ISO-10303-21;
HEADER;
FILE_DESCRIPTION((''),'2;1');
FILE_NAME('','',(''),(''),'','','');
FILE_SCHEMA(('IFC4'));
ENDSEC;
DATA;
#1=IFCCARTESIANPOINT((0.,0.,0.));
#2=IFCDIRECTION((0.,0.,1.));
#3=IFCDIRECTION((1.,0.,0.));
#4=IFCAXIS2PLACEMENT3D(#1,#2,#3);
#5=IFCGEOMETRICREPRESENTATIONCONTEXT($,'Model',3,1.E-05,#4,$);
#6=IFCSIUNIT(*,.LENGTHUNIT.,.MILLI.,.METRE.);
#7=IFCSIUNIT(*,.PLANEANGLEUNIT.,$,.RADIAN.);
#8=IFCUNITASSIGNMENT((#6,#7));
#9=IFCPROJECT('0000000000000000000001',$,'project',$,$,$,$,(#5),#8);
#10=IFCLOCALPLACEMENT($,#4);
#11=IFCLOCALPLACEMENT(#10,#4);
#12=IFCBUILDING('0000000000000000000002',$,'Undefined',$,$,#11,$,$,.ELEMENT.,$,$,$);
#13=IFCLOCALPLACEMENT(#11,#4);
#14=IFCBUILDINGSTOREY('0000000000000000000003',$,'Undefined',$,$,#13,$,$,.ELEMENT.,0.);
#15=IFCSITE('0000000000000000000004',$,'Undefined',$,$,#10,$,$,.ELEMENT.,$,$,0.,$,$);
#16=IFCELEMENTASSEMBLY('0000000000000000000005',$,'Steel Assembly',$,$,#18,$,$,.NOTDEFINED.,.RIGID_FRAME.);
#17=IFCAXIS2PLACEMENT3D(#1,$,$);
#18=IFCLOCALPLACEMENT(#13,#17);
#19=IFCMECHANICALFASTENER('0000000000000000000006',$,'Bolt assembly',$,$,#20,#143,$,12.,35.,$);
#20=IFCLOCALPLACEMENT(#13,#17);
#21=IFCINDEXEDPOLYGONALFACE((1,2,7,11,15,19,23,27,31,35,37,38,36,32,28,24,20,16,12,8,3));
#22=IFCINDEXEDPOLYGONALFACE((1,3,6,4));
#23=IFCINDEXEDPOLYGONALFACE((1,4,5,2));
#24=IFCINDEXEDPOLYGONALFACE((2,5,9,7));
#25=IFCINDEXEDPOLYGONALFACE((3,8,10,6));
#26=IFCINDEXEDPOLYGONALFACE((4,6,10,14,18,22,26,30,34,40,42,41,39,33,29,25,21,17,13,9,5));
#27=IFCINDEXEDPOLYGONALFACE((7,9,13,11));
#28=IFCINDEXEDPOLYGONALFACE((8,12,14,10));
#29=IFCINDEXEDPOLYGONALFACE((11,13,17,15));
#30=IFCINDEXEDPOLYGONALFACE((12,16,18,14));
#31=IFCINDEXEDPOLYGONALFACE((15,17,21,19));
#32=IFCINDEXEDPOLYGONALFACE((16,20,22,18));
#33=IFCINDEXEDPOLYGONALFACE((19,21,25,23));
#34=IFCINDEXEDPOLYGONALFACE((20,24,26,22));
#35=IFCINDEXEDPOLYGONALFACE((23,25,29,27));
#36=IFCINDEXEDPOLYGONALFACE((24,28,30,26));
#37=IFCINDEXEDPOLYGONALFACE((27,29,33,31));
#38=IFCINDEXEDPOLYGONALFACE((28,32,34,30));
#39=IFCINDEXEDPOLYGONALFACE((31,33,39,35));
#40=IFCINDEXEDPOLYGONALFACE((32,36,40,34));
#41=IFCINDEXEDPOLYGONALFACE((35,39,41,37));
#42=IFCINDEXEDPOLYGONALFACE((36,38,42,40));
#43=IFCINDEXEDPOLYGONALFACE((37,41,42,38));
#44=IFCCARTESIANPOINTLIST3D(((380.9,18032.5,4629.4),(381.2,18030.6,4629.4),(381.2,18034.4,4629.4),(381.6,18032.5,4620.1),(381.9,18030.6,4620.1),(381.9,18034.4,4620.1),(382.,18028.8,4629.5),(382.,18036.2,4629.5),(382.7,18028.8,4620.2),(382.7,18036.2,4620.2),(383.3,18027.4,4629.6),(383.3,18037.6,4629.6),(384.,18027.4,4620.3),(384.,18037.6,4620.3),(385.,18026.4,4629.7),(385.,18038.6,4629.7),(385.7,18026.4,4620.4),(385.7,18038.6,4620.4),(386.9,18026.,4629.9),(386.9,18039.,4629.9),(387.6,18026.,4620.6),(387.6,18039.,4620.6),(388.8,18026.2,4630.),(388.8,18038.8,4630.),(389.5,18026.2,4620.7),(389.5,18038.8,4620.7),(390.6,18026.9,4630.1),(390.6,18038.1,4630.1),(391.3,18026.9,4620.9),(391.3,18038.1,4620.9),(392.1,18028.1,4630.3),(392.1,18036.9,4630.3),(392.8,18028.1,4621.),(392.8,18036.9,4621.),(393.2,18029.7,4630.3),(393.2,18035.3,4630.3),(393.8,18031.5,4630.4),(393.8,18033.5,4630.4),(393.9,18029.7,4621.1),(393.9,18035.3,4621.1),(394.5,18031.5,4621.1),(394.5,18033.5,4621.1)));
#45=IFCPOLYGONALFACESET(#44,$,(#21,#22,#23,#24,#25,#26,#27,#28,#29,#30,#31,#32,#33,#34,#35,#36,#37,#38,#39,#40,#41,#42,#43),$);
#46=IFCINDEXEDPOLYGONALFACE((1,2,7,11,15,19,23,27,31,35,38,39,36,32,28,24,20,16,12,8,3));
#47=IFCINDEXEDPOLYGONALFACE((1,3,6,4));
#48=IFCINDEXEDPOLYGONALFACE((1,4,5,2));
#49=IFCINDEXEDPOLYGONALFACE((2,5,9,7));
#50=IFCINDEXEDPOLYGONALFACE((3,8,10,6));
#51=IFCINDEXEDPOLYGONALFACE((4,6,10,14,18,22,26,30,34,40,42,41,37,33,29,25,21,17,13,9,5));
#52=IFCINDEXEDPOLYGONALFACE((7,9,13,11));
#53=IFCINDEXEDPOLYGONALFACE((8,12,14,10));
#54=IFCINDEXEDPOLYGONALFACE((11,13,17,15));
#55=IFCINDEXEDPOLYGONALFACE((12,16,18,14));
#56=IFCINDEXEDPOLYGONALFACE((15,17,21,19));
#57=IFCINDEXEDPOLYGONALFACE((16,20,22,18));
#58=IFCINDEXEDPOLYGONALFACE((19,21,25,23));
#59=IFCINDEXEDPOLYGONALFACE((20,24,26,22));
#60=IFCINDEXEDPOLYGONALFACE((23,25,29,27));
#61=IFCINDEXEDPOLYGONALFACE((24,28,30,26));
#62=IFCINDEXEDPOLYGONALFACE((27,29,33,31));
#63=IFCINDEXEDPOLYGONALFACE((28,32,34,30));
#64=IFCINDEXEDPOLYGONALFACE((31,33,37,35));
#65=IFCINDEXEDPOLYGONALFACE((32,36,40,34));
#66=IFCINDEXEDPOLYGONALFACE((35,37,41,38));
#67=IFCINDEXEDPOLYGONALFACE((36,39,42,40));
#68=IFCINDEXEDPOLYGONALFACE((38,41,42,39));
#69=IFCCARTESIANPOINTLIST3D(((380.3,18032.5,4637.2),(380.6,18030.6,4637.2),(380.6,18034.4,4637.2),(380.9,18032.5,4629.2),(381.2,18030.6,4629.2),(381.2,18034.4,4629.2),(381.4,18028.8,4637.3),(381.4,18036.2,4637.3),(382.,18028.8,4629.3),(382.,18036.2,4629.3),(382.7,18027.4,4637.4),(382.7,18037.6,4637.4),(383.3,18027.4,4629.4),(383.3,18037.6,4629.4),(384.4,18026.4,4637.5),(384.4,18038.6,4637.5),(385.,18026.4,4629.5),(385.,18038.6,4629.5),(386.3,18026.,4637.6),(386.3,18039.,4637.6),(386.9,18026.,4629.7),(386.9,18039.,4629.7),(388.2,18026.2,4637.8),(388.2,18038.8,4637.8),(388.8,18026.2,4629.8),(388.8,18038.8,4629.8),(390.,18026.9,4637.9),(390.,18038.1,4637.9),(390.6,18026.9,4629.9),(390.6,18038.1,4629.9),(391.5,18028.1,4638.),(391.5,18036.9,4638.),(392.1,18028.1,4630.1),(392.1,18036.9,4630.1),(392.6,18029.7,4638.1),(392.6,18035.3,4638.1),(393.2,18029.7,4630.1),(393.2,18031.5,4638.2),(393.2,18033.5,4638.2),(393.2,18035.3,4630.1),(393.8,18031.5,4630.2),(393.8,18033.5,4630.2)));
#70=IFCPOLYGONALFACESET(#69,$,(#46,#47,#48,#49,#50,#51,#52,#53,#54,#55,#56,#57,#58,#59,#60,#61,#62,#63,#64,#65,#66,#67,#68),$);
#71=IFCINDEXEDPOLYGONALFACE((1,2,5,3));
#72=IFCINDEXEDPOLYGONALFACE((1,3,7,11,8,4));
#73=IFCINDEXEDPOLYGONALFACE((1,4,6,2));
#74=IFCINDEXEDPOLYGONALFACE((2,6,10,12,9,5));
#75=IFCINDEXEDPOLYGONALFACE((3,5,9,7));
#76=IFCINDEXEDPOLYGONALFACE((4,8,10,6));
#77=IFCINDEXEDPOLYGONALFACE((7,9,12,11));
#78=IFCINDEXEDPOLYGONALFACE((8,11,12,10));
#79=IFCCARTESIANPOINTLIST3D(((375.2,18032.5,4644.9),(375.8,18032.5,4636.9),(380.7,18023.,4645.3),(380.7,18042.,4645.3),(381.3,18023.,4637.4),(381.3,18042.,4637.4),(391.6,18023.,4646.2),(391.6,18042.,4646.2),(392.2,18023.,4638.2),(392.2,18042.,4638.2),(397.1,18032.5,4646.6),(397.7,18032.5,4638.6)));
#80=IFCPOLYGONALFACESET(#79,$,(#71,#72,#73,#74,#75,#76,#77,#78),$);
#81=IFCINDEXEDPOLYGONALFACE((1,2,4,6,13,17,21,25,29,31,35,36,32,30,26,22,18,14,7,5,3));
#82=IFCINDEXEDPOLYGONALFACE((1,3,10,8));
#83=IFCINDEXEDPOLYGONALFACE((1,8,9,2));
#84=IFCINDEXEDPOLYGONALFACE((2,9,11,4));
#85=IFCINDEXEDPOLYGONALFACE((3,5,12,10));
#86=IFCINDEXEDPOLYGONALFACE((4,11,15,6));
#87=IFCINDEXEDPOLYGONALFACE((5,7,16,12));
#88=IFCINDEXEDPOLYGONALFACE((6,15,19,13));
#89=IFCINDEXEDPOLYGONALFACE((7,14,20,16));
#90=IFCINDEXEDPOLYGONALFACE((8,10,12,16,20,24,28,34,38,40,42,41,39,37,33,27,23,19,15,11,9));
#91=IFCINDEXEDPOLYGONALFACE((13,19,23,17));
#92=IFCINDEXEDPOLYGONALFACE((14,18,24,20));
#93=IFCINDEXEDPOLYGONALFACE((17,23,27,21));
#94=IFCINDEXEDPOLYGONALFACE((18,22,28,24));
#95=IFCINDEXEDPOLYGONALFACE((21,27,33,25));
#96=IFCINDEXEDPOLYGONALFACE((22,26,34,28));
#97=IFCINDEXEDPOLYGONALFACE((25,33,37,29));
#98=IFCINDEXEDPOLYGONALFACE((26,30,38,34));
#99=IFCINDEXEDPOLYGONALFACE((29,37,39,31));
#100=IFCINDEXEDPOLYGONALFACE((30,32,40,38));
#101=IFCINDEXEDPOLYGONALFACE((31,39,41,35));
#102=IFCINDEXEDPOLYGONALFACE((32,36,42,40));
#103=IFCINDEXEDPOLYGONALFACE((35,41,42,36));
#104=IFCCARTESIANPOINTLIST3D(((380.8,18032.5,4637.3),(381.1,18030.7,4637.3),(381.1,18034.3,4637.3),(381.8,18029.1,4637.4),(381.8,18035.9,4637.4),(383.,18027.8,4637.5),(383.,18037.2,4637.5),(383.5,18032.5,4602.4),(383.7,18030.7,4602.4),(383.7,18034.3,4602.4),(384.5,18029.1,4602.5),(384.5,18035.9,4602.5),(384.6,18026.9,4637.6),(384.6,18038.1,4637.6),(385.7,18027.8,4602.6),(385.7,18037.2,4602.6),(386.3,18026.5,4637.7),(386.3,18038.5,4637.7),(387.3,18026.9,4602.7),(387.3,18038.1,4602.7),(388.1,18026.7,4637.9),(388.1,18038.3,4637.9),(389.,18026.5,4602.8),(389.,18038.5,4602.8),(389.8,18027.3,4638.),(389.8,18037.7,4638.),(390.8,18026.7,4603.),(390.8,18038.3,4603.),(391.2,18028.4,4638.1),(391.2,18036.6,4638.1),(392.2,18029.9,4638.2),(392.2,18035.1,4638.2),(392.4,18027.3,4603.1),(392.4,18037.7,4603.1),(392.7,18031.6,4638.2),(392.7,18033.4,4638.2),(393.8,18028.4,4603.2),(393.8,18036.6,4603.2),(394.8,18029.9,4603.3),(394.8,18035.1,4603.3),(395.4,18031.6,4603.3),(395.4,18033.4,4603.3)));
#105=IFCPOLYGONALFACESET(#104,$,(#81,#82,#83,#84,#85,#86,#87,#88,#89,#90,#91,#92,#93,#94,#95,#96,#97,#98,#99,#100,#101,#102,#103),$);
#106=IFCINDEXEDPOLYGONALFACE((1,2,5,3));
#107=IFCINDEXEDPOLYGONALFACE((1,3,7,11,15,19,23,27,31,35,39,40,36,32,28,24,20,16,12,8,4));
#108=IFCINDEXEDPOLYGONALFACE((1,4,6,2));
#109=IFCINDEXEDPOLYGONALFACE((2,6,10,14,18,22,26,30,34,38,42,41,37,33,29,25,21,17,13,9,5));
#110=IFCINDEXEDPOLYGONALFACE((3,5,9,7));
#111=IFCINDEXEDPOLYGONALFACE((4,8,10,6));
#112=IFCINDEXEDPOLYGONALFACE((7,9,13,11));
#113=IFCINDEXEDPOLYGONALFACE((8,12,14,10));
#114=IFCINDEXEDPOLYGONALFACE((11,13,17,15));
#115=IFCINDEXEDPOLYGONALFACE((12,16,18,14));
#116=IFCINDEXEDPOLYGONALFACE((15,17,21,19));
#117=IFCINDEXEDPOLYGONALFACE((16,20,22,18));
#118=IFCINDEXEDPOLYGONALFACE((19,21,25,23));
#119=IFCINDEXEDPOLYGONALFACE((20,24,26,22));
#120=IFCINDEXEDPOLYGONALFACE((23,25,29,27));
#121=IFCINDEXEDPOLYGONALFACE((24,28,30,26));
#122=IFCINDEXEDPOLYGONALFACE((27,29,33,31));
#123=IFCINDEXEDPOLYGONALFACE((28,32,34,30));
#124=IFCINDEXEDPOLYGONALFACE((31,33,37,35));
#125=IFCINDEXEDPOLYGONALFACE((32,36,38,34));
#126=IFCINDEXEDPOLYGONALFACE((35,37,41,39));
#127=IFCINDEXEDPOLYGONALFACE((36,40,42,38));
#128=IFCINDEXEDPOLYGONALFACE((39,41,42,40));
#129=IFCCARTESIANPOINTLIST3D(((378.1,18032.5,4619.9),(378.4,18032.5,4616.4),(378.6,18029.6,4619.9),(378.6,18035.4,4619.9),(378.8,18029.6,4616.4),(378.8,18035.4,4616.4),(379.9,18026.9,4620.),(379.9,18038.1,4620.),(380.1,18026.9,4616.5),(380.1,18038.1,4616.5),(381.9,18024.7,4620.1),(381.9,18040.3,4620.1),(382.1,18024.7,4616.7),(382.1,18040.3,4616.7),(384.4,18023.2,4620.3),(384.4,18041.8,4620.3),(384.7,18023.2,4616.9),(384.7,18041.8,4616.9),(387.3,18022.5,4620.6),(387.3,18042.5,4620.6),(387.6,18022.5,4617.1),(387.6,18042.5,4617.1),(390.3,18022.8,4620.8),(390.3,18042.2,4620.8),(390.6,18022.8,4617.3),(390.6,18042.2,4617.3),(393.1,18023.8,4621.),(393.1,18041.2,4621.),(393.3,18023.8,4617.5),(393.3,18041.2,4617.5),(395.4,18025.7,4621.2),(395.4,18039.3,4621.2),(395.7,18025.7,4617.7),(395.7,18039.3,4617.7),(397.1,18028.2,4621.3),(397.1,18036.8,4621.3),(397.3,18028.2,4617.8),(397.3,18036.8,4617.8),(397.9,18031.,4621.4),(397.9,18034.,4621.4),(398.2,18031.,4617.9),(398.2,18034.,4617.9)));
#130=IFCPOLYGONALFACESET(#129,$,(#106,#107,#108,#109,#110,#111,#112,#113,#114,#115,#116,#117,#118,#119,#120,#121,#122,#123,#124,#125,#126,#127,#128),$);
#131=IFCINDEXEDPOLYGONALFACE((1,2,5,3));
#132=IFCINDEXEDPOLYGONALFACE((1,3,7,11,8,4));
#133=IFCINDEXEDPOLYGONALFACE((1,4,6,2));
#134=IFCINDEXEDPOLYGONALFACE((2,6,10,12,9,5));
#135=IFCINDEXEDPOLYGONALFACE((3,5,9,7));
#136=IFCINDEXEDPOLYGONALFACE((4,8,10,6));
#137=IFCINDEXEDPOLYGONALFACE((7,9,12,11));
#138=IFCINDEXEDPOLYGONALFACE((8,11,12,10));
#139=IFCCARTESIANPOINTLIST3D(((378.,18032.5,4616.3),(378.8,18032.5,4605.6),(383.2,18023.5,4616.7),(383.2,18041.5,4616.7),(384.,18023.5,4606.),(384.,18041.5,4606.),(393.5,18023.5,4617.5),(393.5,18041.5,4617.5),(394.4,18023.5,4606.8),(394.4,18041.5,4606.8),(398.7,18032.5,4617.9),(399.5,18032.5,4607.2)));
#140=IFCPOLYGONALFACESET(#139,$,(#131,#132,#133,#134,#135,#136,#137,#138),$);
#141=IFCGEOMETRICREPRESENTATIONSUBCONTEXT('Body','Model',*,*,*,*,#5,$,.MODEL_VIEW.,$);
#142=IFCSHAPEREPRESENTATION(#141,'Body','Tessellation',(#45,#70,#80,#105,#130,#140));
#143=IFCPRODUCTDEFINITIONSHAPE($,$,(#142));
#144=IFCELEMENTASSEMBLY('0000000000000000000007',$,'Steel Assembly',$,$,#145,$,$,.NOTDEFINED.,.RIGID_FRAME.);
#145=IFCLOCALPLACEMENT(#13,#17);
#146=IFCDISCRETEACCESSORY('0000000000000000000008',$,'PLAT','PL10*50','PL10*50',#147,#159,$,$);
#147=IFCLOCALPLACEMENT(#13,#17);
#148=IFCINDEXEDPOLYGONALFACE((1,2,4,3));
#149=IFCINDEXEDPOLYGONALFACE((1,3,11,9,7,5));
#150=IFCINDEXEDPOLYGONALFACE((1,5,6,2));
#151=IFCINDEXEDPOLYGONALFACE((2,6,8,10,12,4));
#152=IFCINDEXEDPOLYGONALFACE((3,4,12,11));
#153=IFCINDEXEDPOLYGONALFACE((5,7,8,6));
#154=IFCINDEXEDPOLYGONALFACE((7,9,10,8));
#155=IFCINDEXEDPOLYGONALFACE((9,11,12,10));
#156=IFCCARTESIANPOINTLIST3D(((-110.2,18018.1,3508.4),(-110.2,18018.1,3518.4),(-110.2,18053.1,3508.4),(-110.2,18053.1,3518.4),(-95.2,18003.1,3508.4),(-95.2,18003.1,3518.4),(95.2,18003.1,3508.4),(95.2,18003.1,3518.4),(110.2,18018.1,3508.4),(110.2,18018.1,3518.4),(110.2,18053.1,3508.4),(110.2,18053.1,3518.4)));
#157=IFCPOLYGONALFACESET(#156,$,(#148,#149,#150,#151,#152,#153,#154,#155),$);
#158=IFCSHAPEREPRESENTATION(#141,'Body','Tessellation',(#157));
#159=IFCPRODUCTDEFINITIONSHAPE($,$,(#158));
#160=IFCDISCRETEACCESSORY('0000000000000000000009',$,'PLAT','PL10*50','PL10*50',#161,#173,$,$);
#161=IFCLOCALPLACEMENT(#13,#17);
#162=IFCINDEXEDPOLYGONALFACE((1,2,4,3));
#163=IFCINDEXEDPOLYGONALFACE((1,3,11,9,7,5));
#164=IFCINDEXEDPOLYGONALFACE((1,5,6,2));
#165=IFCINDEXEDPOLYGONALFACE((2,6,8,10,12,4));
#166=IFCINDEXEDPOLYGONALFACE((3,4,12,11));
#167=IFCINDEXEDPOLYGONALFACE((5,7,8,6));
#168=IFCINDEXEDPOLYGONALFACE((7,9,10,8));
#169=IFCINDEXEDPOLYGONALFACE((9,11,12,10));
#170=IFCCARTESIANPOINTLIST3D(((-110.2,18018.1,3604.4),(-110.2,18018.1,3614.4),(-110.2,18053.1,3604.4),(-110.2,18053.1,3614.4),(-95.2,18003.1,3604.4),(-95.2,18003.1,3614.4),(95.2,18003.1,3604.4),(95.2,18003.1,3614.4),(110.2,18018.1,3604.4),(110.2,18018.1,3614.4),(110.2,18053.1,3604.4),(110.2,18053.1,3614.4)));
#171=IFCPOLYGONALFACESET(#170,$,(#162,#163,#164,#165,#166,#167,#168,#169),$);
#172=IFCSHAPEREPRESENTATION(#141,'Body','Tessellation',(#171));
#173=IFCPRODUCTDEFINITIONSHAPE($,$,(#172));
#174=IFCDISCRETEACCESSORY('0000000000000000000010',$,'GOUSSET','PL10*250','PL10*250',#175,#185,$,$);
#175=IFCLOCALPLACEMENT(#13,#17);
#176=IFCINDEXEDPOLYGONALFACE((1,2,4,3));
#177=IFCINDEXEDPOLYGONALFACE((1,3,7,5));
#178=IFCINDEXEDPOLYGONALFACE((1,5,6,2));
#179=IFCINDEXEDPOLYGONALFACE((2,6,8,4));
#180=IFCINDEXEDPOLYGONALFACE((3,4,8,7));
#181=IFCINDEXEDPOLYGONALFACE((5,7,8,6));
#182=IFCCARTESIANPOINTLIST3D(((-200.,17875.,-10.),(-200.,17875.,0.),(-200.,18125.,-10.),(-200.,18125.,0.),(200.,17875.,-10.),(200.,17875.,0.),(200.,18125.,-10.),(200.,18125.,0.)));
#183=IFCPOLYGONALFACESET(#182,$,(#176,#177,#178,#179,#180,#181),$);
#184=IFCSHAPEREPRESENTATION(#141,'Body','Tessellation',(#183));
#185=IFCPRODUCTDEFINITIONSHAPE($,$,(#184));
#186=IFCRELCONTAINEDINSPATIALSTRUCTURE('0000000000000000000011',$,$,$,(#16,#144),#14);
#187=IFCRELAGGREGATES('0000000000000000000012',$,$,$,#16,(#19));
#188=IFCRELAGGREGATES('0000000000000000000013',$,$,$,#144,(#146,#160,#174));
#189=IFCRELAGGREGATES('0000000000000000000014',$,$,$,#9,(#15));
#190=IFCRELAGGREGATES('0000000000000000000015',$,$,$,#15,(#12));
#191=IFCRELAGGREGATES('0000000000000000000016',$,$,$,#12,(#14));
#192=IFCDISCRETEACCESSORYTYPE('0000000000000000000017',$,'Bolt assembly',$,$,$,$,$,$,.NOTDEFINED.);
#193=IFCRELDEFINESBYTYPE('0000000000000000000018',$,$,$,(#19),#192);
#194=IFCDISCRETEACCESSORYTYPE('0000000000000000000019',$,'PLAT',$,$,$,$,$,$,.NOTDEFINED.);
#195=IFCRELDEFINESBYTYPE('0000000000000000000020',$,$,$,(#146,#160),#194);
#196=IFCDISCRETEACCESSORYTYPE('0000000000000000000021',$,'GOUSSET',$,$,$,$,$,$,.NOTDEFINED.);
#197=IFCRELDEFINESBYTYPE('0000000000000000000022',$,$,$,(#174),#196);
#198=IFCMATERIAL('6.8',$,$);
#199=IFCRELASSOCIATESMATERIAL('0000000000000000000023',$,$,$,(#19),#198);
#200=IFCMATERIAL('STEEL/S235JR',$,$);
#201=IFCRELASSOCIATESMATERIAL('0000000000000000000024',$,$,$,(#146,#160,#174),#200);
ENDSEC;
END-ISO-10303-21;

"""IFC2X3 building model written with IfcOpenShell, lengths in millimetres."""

from ifc_helpers import new_model, si_unit, frame, origin_with_axes, origin_2d_with_axis, place, context, subcontext, project, spatial, polyline, circle, outline, extrude, source, transform, mapped, material, type_object, element, aggregate, save


model = new_model("IFC2X3")

# Units and contexts
model_context = context("Model", 3, precision=1e-05, world=origin_with_axes())
body_context = subcontext(model_context, "Body", "Model", "MODEL_VIEW")
ifc_project = project(units=[si_unit("LENGTHUNIT", "METRE", prefix="MILLI"), si_unit("PLANEANGLEUNIT", "RADIAN")], contexts=[model_context])

# Site, building, storey
site_placement = place(None, origin_with_axes())
site = spatial("IfcSite", under=ifc_project, at=site_placement, Name="Undefined", CompositionType="ELEMENT", RefElevation=0.0)
building_placement = place(site_placement, origin_with_axes())
building = spatial("IfcBuilding", under=site, at=building_placement, Name="Undefined", CompositionType="ELEMENT")
storey_placement = place(building_placement, origin_with_axes())
storey = spatial("IfcBuildingStorey", under=building, at=storey_placement, Name="Undefined", CompositionType="ELEMENT", Elevation=0.0)

# Shared definitions
ifc_material_1 = material(Name="STEEL/S235JR")

# Element assembly, mechanical fastener
ifc_material_2 = material(Name="6.8")
discrete_accessory_type_1 = type_object("IfcDiscreteAccessoryType", Name="Bolt assembly")
shared_shape_1 = source(origin_with_axes(), body_context, "Body", "SweptSolid", [
    extrude(circle(Radius=6.5, at=origin_2d_with_axis()), frame((0.0, -0.1, 0.0), z_axis=(0.0, 1.0, 0.0), x_axis=(1.0, 0.0, 0.0)), (0.0, 0.0, 1.0), 9.3),
    extrude(circle(Radius=6.5, at=origin_2d_with_axis()), frame((0.0, -7.9, 0.0), z_axis=(0.0, 1.0, 0.0), x_axis=(1.0, 0.0, 0.0)), (0.0, 0.0, 1.0), 8.0),
    extrude(outline(polyline([(11.0, 0.0), (5.5, 9.5), (-5.5, 9.5), (-11.0, 0.0), (-5.5, -9.5), (5.5, -9.5), (11.0, 0.0)])), frame((0.0, -16.0, 0.0), z_axis=(0.0, 1.0, 0.0), x_axis=(1.0, 0.0, 0.0)), (0.0, 0.0, 1.0), 8.0),
    extrude(circle(Radius=6.0, at=origin_2d_with_axis()), frame((0.0, -8.0, 0.0), z_axis=(0.0, 1.0, 0.0), x_axis=(1.0, 0.0, 0.0)), (0.0, 0.0, 1.0), 35.0),
    extrude(circle(Radius=10.0, at=origin_2d_with_axis()), frame((0.0, 9.2, 0.0), z_axis=(0.0, 1.0, 0.0), x_axis=(1.0, 0.0, 0.0)), (0.0, 0.0, 1.0), 3.5),
    extrude(outline(polyline([(10.4, 0.0), (5.2, 9.0), (-5.2, 9.0), (-10.4, 0.0), (-5.2, -9.0), (5.2, -9.0), (10.4, 0.0)])), frame((0.0, 12.7, 0.0), z_axis=(0.0, 1.0, 0.0), x_axis=(1.0, 0.0, 0.0)), (0.0, 0.0, 1.0), 10.8),
])
assembly_1_placement = place(storey_placement, origin_with_axes())
assembly_1 = element("IfcElementAssembly", 1, at=assembly_1_placement, inside=storey, Name="Steel Assembly", AssemblyPlace="NOTDEFINED", PredefinedType="RIGID_FRAME")
mechanical_fastener_1_placement = place(assembly_1_placement, frame((387.4, 18032.5, 4629.8), z_axis=(0.0, -1.0, 0.0), x_axis=(-0.997054, 0.0, -0.076696)))
mechanical_fastener_1 = element("IfcMechanicalFastener", 2, at=mechanical_fastener_1_placement, type_object=discrete_accessory_type_1, material=ifc_material_2, Name="Bolt assembly", NominalDiameter=12.0, NominalLength=35.0, context=body_context, shape_type="MappedRepresentation", body=[
    mapped(shared_shape_1, transform((0.0, 0.0, 0.0))),
])
aggregate(assembly_1, [mechanical_fastener_1])

# Element assembly, discrete accessories
assembly_2_placement = place(storey_placement, origin_with_axes())
assembly_2 = element("IfcElementAssembly", 3, at=assembly_2_placement, inside=storey, Name="Steel Assembly", AssemblyPlace="NOTDEFINED", PredefinedType="RIGID_FRAME")
discrete_accessory_type_2 = type_object("IfcDiscreteAccessoryType", Name="PLAT")
discrete_accessory_1_placement = place(assembly_2_placement, frame((-110.2, 18003.1, 3513.4), z_axis=(0.0, 0.0, -1.0), x_axis=(0.0, 1.0, 0.0)))
discrete_accessory_1 = element("IfcDiscreteAccessory", 4, at=discrete_accessory_1_placement, type_object=discrete_accessory_type_2, material=ifc_material_1, Name="PLAT", Description="PL10*50", ObjectType="PL10*50", context=body_context, shape_type="SweptSolid", body=[
    extrude(outline(polyline([(0.0, 15.0), (15.0, 0.0), (50.0, 0.0), (50.0, 220.4), (15.0, 220.4), (0.0, 205.4), (0.0, 15.0)])), frame((0.0, 0.0, -5.0), z_axis=(0.0, 0.0, 1.0), x_axis=(1.0, 0.0, 0.0)), (0.0, 0.0, 1.0), 10.0),
])
discrete_accessory_2_placement = place(assembly_2_placement, frame((-110.2, 18003.1, 3609.4), z_axis=(0.0, 0.0, -1.0), x_axis=(0.0, 1.0, 0.0)))
discrete_accessory_2 = element("IfcDiscreteAccessory", 5, at=discrete_accessory_2_placement, type_object=discrete_accessory_type_2, material=ifc_material_1, Name="PLAT", Description="PL10*50", ObjectType="PL10*50", context=body_context, shape_type="SweptSolid", body=[
    extrude(outline(polyline([(0.0, 15.0), (15.0, 0.0), (50.0, 0.0), (50.0, 220.4), (15.0, 220.4), (0.0, 205.4), (0.0, 15.0)])), frame((0.0, 0.0, -5.0), z_axis=(0.0, 0.0, 1.0), x_axis=(1.0, 0.0, 0.0)), (0.0, 0.0, 1.0), 10.0),
])
discrete_accessory_type_3 = type_object("IfcDiscreteAccessoryType", Name="GOUSSET")
discrete_accessory_3_placement = place(assembly_2_placement, frame((-200.0, 18125.0, -5.0), z_axis=(0.0, 0.0, 1.0), x_axis=(0.0, -1.0, 0.0)))
discrete_accessory_3 = element("IfcDiscreteAccessory", 6, at=discrete_accessory_3_placement, type_object=discrete_accessory_type_3, material=ifc_material_1, Name="GOUSSET", Description="PL10*250", ObjectType="PL10*250", context=body_context, shape_type="SweptSolid", body=[
    extrude(outline(polyline([(0.0, 0.0), (250.0, 0.0), (250.0, 400.0), (0.0, 400.0), (0.0, 0.0)])), frame((0.0, 0.0, -5.0), z_axis=(0.0, 0.0, 1.0), x_axis=(1.0, 0.0, 0.0)), (0.0, 0.0, 1.0), 10.0),
])

aggregate(assembly_2, [discrete_accessory_1, discrete_accessory_2, discrete_accessory_3])

save(model, "model.ifc")
